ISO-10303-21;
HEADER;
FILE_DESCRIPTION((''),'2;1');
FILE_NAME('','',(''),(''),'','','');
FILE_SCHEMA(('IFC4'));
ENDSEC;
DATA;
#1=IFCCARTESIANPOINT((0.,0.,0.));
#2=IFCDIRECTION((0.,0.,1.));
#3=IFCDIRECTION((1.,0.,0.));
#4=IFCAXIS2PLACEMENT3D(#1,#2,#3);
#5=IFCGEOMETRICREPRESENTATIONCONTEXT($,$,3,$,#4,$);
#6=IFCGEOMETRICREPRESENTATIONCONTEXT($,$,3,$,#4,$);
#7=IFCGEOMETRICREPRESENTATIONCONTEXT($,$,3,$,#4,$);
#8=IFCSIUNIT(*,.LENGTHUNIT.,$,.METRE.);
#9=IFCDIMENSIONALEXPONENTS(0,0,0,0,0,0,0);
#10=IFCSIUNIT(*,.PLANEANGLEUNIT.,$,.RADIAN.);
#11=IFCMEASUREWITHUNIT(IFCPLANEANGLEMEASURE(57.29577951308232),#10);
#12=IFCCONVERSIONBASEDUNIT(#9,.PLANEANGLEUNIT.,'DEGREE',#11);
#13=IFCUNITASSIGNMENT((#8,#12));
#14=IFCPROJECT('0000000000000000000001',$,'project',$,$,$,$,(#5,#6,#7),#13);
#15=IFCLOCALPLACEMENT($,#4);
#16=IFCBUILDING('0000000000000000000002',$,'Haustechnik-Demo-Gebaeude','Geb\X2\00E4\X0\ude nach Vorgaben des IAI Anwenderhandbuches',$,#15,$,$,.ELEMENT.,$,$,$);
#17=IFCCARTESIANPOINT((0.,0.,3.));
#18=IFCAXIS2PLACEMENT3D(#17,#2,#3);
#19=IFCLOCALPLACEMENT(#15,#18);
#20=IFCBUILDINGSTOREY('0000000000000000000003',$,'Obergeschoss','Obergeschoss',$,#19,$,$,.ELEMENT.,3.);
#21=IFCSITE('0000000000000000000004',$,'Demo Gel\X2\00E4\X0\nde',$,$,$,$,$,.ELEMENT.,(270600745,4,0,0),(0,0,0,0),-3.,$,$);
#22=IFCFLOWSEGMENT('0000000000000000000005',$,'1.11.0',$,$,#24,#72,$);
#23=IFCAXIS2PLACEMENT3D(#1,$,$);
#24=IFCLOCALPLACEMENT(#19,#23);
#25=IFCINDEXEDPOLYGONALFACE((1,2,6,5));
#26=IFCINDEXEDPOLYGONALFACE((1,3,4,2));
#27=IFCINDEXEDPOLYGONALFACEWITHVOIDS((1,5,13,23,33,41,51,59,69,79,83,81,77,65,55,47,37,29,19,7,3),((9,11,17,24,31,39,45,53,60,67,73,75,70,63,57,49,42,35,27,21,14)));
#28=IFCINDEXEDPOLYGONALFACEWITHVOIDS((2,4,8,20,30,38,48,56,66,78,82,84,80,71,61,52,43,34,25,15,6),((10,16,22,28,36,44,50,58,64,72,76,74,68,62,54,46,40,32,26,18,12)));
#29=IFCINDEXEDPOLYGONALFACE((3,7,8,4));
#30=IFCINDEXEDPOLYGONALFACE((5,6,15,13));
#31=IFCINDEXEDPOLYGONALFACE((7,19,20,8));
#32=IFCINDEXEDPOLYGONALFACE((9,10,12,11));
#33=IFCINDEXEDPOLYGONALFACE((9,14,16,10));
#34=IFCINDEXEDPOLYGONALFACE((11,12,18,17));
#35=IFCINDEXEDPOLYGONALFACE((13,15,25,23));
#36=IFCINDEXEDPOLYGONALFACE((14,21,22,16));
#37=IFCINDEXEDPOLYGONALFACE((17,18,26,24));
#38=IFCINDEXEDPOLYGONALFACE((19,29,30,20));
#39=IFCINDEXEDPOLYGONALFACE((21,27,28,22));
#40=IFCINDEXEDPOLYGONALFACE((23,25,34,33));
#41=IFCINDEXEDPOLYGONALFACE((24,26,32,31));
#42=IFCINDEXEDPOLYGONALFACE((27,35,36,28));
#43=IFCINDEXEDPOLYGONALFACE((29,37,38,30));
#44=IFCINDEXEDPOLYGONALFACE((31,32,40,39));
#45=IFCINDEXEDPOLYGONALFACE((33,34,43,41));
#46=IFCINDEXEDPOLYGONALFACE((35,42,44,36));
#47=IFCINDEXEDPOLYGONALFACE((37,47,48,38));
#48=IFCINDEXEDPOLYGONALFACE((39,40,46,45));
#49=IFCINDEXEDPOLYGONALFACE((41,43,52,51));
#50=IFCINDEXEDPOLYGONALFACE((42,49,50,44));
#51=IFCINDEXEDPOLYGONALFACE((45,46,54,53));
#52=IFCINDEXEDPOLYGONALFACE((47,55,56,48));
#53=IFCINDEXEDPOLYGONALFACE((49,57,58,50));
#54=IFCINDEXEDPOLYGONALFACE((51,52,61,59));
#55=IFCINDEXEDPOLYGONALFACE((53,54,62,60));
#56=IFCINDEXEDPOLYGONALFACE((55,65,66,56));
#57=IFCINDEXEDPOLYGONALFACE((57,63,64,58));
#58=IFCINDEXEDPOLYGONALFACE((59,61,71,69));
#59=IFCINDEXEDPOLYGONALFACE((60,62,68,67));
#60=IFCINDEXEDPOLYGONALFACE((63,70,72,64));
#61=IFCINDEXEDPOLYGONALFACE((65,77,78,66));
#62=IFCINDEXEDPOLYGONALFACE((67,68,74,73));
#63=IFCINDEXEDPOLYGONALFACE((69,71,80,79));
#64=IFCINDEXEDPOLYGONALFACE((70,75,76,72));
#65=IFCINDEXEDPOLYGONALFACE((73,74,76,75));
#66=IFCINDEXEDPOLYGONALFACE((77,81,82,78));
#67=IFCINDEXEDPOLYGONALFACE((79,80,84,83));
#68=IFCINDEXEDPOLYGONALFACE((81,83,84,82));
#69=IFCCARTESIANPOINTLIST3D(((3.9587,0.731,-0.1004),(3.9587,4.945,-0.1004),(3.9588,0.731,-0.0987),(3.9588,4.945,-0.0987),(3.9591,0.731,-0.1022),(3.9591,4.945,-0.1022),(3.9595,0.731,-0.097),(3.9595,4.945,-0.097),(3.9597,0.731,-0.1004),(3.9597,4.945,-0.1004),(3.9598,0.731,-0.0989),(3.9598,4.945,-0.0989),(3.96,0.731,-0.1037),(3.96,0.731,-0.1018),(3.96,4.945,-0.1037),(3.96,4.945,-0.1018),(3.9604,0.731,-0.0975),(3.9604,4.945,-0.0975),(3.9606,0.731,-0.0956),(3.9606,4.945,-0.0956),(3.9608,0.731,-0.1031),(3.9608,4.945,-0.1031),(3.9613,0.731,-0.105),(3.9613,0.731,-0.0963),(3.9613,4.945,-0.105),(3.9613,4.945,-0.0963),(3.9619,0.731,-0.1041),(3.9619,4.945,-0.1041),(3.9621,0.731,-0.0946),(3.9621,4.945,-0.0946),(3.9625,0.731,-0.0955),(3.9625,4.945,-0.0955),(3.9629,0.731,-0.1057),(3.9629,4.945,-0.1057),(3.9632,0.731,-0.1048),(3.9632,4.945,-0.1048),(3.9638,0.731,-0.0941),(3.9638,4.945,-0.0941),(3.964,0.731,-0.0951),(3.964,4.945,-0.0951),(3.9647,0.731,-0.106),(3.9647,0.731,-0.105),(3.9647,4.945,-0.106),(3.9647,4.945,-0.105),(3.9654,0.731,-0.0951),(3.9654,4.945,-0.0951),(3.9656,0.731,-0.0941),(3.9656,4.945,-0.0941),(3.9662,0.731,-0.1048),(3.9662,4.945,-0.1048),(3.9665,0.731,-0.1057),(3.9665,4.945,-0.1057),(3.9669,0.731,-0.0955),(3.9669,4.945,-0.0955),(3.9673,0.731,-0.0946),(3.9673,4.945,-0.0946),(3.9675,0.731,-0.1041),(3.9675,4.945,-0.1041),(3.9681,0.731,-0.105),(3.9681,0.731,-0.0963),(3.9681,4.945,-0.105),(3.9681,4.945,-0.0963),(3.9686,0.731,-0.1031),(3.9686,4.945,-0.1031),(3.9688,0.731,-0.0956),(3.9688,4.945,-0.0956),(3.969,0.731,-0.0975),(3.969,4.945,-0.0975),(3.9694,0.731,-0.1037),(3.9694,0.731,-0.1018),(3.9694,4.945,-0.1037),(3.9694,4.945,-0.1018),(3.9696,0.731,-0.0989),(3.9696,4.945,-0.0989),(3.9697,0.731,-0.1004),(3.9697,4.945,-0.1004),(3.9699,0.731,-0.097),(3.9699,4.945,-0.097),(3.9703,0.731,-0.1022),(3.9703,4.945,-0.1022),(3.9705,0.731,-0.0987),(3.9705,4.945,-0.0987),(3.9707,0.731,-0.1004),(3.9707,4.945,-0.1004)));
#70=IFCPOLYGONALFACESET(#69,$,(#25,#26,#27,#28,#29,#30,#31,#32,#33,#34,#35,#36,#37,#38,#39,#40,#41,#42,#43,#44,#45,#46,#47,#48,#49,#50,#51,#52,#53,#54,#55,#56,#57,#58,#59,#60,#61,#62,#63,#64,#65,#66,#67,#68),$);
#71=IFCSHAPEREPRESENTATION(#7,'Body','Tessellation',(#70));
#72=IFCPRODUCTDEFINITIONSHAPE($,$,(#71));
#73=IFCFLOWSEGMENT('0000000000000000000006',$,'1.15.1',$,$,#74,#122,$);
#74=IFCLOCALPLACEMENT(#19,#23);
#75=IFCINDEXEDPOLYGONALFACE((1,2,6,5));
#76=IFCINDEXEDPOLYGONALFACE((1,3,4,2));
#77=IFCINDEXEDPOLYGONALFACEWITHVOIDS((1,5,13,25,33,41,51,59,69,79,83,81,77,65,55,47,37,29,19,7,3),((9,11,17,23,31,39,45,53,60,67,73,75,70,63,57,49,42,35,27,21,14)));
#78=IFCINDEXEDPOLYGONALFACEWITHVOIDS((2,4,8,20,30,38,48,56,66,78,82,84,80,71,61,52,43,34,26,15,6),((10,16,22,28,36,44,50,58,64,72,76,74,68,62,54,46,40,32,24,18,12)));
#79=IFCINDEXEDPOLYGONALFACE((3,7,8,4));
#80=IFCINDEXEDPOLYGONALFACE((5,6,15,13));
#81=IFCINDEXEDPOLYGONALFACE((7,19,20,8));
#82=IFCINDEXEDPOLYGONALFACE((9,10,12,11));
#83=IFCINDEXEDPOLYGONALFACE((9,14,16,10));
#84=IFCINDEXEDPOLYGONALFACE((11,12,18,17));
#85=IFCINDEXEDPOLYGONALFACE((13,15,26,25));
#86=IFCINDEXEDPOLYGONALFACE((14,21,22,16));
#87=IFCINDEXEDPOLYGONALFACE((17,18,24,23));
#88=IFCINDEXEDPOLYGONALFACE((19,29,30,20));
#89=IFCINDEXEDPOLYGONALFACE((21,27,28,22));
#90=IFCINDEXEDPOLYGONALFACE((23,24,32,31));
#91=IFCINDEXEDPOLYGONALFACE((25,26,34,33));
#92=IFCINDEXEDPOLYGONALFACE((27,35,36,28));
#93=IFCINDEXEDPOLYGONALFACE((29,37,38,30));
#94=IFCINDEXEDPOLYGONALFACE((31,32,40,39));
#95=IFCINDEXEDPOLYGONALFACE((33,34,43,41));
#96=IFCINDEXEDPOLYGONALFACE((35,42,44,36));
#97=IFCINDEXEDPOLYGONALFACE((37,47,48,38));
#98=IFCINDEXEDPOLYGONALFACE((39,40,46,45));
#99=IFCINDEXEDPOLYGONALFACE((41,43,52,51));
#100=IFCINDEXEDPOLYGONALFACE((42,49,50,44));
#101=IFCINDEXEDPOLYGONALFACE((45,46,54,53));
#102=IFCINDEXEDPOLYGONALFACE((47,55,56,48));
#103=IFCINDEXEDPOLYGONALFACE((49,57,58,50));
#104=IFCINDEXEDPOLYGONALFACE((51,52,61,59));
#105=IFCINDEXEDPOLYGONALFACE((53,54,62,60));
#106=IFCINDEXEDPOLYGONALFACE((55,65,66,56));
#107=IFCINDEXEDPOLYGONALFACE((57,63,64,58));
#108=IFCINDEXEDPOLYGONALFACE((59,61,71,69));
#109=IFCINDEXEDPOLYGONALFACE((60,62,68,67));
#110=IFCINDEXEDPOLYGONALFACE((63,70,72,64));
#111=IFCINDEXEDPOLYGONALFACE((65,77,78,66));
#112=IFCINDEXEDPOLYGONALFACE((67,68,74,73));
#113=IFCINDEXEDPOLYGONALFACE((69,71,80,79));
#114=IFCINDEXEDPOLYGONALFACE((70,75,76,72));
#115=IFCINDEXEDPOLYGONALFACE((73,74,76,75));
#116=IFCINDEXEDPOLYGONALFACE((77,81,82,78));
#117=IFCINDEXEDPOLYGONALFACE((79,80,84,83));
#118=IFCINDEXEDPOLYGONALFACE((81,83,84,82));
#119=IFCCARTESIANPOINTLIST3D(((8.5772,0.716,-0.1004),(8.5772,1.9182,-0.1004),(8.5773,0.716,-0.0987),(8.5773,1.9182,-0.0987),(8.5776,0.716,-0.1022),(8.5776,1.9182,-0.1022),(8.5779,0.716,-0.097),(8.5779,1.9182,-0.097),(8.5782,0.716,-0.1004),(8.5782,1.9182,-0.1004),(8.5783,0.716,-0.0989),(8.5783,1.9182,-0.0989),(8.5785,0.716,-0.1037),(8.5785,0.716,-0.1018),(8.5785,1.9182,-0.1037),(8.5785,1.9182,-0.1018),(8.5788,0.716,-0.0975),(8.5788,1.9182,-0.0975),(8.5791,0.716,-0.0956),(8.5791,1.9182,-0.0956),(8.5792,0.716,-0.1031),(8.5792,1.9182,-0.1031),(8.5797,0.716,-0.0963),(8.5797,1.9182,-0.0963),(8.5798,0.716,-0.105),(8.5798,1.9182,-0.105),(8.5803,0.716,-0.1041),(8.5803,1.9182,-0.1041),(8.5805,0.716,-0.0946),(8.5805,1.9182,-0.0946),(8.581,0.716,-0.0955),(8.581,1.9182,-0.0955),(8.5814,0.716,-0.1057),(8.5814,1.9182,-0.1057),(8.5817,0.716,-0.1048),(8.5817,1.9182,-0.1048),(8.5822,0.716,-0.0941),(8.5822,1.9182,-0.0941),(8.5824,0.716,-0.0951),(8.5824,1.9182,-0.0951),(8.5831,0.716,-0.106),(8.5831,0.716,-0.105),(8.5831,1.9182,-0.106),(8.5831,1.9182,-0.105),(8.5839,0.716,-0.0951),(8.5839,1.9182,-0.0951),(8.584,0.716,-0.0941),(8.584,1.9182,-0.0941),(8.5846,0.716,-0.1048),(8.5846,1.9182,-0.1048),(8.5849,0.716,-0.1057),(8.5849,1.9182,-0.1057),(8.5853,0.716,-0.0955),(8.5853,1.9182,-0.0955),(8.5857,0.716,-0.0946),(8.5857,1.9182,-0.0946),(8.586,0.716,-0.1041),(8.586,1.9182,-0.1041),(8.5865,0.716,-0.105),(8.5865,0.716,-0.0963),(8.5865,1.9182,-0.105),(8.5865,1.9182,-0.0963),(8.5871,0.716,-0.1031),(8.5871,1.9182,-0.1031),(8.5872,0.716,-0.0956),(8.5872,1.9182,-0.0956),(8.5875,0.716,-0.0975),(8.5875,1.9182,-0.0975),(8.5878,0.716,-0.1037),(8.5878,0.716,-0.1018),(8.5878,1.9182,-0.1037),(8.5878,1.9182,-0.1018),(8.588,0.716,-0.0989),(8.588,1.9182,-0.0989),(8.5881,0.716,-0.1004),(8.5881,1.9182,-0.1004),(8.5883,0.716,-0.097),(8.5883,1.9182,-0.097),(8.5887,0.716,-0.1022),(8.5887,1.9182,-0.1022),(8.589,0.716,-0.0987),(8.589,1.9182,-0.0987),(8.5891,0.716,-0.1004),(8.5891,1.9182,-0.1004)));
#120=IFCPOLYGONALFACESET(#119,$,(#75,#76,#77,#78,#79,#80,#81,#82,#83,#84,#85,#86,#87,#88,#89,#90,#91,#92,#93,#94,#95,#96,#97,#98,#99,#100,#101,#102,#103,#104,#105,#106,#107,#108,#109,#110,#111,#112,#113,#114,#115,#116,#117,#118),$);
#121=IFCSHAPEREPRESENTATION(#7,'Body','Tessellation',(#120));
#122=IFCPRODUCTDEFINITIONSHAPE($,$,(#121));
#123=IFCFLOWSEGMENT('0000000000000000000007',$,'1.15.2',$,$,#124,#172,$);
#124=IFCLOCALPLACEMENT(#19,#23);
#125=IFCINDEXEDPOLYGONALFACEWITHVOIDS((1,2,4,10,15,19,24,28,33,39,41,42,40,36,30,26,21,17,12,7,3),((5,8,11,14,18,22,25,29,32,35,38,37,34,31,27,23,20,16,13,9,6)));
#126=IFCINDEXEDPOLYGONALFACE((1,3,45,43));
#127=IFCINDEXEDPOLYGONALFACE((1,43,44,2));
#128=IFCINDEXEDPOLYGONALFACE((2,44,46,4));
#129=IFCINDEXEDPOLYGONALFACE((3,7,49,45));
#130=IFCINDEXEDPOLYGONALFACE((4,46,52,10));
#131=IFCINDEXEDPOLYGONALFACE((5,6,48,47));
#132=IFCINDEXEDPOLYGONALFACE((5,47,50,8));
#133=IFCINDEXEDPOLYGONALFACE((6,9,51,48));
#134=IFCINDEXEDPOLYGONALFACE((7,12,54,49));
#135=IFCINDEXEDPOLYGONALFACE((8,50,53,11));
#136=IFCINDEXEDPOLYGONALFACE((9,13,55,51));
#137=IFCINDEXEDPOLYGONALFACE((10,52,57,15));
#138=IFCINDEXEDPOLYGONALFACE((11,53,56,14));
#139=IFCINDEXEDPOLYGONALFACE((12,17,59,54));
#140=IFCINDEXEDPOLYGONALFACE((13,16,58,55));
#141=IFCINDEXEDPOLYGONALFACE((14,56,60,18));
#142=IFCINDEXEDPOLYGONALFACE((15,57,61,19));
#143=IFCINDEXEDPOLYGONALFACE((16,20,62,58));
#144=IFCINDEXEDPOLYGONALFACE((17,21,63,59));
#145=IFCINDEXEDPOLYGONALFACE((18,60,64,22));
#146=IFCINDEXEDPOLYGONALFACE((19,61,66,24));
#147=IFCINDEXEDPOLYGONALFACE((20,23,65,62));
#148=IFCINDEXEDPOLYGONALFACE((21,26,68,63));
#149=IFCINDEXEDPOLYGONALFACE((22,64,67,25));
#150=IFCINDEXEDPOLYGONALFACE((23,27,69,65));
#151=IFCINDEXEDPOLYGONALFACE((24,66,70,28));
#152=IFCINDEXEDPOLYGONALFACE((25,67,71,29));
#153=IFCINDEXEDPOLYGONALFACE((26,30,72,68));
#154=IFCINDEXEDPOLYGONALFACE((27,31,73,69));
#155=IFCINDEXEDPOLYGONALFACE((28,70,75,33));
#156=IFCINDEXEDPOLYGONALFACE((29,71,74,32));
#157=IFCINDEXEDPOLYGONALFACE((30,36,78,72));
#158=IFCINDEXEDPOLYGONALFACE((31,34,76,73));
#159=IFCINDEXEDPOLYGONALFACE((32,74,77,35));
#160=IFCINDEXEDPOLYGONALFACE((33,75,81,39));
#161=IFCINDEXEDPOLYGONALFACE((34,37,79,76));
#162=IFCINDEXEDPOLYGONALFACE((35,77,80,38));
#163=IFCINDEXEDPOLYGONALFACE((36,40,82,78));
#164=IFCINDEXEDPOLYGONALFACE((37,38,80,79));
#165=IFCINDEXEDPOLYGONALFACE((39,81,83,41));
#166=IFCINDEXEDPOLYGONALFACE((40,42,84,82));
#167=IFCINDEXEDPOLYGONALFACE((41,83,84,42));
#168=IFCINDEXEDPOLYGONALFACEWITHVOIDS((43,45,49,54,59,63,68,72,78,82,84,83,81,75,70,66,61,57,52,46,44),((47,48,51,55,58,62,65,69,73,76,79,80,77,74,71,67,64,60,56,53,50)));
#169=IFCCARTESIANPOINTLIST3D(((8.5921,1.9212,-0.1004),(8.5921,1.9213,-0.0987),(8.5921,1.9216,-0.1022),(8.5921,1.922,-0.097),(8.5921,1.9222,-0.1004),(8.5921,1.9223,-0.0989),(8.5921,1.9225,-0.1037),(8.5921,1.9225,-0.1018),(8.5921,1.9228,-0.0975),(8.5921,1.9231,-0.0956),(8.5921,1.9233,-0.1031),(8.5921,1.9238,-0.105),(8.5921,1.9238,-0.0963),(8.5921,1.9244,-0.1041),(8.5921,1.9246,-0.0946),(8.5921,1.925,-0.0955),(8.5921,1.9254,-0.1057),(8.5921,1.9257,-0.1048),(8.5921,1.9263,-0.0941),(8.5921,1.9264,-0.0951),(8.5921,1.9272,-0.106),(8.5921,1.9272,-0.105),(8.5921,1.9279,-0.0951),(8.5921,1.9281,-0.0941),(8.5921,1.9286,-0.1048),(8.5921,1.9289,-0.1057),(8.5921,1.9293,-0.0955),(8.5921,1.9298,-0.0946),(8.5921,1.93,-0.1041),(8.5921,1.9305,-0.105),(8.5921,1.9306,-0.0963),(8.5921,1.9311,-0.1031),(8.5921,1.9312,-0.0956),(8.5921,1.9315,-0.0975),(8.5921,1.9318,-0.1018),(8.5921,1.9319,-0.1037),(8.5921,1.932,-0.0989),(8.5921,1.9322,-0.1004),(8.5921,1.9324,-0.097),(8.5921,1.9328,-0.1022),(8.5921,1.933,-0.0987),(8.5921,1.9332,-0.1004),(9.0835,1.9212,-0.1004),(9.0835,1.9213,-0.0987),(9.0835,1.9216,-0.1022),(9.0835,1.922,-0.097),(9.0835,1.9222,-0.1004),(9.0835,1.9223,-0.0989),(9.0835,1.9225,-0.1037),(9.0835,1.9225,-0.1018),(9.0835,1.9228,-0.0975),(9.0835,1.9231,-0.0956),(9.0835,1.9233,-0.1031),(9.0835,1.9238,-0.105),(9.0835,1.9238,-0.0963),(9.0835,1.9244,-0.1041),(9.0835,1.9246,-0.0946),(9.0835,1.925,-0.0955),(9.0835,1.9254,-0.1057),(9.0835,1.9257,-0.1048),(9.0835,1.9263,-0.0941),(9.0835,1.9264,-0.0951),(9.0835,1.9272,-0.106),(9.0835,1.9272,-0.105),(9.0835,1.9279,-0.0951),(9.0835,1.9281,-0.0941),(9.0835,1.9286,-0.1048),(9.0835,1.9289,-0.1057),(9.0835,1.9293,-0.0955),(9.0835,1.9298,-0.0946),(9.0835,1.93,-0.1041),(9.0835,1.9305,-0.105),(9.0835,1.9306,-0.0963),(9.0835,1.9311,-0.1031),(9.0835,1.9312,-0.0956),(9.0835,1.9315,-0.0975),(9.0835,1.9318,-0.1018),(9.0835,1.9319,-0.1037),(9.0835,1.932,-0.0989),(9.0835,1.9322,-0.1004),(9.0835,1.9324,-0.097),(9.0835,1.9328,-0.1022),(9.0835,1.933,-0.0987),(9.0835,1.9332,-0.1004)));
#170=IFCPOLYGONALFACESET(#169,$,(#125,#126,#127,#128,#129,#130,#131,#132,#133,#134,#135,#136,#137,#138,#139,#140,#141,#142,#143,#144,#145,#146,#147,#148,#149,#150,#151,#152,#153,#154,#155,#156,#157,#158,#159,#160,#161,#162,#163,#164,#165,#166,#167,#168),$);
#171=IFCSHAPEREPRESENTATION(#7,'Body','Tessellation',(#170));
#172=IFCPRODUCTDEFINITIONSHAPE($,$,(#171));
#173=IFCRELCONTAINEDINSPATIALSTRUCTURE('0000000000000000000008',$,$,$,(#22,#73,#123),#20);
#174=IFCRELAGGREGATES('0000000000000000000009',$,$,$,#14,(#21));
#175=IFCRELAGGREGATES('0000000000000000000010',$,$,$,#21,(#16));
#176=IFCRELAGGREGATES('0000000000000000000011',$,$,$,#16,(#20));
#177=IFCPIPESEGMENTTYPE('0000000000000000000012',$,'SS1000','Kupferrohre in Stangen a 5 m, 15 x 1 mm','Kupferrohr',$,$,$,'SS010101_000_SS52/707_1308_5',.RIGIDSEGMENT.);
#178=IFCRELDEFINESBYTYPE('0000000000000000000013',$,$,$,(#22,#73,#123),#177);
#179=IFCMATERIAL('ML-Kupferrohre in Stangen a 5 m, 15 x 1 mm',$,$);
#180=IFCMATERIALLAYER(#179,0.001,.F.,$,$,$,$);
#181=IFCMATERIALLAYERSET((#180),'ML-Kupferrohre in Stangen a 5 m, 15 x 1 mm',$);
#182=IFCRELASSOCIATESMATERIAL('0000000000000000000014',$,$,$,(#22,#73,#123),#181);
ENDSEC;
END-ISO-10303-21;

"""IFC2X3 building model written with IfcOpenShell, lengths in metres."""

from ifc_helpers import new_model, entity, si_unit, converted_unit, frame, origin_with_axes, origin_2d_with_axis, place, context, project, spatial, hollow_circle, extrude, material, layer, layer_set, layer_usage, type_object, element, save


model = new_model("IFC2X3")

# Units and contexts
context_of_model_1 = context(None, 3, world=origin_with_axes())
context_of_model_2 = context(None, 3, world=origin_with_axes())
context_of_model_3 = context(None, 3, world=origin_with_axes())
ifc_project = project(units=[si_unit("LENGTHUNIT", "METRE"), converted_unit("PLANEANGLEUNIT", "DEGREE", entity("IfcPlaneAngleMeasure", 57.29577951308232), si_unit("PLANEANGLEUNIT", "RADIAN"), dimensions=[0, 0, 0, 0, 0, 0, 0])], contexts=[context_of_model_1, context_of_model_2, context_of_model_3])

# Site, building, storey
site = spatial("IfcSite", under=ifc_project, Name="Demo Gelände", CompositionType="ELEMENT", RefLatitude=(270600745, 4, 0, 0), RefLongitude=(0, 0, 0, 0), RefElevation=-3.0)
building_placement = place(None, origin_with_axes())
building = spatial("IfcBuilding", under=site, at=building_placement, Name="Haustechnik-Demo-Gebaeude", Description="Gebäude nach Vorgaben des IAI Anwenderhandbuches", CompositionType="ELEMENT")
storey_placement = place(building_placement, frame((0.0, 0.0, 3.0), z_axis=(0.0, 0.0, 1.0), x_axis=(1.0, 0.0, 0.0)))
storey = spatial("IfcBuildingStorey", under=building, at=storey_placement, Name="Obergeschoss", Description="Obergeschoss", CompositionType="ELEMENT", Elevation=3.0)

# Flow segments
ifc_material = material(Name="ML-Kupferrohre in Stangen a 5 m, 15 x 1 mm")
ifc_layer = layer(ifc_material, 0.001, ventilated=False)
ifc_layer_set = layer_set([ifc_layer], Name="ML-Kupferrohre in Stangen a 5 m, 15 x 1 mm")
ifc_layer_usage = layer_usage(ifc_layer_set, "AXIS2", "POSITIVE", 0.0)
pipe_segment_type_1 = type_object("IfcPipeSegmentType", Name="SS1000", Description="Kupferrohre in Stangen a 5 m, 15 x 1 mm", ApplicableOccurrence="Kupferrohr", ElementType="SS010101_000_SS52/707_1308_5", PredefinedType="RIGIDSEGMENT")
flow_segment_1_placement = place(storey_placement, frame((3.9647, 4.945, -0.1), z_axis=(0.0, -1.0, 0.0), x_axis=(0.0, 0.0, -1.0)))
element("IfcFlowSegment", 1, at=flow_segment_1_placement, inside=storey, type_object=pipe_segment_type_1, material=ifc_layer_usage, Name="1.11.0", context=context_of_model_3, shape_type="SweptSolid", body=[
    extrude(hollow_circle(Radius=0.006, WallThickness=0.001, at=origin_2d_with_axis()), origin_with_axes(), (0.0, 0.0, 1.0), 4.214),
])
flow_segment_2_placement = place(storey_placement, frame((8.5831, 0.716, -0.1), z_axis=(0.0, 1.0, 0.0), x_axis=(0.0, 0.0, -1.0)))
element("IfcFlowSegment", 2, at=flow_segment_2_placement, inside=storey, type_object=pipe_segment_type_1, material=ifc_layer_usage, Name="1.15.1", context=context_of_model_3, shape_type="SweptSolid", body=[
    extrude(hollow_circle(Radius=0.006, WallThickness=0.001, at=origin_2d_with_axis()), origin_with_axes(), (0.0, 0.0, 1.0), 1.2022),
])
flow_segment_3_placement = place(storey_placement, frame((8.5921, 1.9272, -0.1), z_axis=(1.0, 0.0, 0.0), x_axis=(0.0, 0.0, -1.0)))
element("IfcFlowSegment", 3, at=flow_segment_3_placement, inside=storey, type_object=pipe_segment_type_1, material=ifc_layer_usage, Name="1.15.2", context=context_of_model_3, shape_type="SweptSolid", body=[
    extrude(hollow_circle(Radius=0.006, WallThickness=0.001, at=origin_2d_with_axis()), origin_with_axes(), (0.0, 0.0, 1.0), 0.4914),
])

save(model, "model.ifc")
